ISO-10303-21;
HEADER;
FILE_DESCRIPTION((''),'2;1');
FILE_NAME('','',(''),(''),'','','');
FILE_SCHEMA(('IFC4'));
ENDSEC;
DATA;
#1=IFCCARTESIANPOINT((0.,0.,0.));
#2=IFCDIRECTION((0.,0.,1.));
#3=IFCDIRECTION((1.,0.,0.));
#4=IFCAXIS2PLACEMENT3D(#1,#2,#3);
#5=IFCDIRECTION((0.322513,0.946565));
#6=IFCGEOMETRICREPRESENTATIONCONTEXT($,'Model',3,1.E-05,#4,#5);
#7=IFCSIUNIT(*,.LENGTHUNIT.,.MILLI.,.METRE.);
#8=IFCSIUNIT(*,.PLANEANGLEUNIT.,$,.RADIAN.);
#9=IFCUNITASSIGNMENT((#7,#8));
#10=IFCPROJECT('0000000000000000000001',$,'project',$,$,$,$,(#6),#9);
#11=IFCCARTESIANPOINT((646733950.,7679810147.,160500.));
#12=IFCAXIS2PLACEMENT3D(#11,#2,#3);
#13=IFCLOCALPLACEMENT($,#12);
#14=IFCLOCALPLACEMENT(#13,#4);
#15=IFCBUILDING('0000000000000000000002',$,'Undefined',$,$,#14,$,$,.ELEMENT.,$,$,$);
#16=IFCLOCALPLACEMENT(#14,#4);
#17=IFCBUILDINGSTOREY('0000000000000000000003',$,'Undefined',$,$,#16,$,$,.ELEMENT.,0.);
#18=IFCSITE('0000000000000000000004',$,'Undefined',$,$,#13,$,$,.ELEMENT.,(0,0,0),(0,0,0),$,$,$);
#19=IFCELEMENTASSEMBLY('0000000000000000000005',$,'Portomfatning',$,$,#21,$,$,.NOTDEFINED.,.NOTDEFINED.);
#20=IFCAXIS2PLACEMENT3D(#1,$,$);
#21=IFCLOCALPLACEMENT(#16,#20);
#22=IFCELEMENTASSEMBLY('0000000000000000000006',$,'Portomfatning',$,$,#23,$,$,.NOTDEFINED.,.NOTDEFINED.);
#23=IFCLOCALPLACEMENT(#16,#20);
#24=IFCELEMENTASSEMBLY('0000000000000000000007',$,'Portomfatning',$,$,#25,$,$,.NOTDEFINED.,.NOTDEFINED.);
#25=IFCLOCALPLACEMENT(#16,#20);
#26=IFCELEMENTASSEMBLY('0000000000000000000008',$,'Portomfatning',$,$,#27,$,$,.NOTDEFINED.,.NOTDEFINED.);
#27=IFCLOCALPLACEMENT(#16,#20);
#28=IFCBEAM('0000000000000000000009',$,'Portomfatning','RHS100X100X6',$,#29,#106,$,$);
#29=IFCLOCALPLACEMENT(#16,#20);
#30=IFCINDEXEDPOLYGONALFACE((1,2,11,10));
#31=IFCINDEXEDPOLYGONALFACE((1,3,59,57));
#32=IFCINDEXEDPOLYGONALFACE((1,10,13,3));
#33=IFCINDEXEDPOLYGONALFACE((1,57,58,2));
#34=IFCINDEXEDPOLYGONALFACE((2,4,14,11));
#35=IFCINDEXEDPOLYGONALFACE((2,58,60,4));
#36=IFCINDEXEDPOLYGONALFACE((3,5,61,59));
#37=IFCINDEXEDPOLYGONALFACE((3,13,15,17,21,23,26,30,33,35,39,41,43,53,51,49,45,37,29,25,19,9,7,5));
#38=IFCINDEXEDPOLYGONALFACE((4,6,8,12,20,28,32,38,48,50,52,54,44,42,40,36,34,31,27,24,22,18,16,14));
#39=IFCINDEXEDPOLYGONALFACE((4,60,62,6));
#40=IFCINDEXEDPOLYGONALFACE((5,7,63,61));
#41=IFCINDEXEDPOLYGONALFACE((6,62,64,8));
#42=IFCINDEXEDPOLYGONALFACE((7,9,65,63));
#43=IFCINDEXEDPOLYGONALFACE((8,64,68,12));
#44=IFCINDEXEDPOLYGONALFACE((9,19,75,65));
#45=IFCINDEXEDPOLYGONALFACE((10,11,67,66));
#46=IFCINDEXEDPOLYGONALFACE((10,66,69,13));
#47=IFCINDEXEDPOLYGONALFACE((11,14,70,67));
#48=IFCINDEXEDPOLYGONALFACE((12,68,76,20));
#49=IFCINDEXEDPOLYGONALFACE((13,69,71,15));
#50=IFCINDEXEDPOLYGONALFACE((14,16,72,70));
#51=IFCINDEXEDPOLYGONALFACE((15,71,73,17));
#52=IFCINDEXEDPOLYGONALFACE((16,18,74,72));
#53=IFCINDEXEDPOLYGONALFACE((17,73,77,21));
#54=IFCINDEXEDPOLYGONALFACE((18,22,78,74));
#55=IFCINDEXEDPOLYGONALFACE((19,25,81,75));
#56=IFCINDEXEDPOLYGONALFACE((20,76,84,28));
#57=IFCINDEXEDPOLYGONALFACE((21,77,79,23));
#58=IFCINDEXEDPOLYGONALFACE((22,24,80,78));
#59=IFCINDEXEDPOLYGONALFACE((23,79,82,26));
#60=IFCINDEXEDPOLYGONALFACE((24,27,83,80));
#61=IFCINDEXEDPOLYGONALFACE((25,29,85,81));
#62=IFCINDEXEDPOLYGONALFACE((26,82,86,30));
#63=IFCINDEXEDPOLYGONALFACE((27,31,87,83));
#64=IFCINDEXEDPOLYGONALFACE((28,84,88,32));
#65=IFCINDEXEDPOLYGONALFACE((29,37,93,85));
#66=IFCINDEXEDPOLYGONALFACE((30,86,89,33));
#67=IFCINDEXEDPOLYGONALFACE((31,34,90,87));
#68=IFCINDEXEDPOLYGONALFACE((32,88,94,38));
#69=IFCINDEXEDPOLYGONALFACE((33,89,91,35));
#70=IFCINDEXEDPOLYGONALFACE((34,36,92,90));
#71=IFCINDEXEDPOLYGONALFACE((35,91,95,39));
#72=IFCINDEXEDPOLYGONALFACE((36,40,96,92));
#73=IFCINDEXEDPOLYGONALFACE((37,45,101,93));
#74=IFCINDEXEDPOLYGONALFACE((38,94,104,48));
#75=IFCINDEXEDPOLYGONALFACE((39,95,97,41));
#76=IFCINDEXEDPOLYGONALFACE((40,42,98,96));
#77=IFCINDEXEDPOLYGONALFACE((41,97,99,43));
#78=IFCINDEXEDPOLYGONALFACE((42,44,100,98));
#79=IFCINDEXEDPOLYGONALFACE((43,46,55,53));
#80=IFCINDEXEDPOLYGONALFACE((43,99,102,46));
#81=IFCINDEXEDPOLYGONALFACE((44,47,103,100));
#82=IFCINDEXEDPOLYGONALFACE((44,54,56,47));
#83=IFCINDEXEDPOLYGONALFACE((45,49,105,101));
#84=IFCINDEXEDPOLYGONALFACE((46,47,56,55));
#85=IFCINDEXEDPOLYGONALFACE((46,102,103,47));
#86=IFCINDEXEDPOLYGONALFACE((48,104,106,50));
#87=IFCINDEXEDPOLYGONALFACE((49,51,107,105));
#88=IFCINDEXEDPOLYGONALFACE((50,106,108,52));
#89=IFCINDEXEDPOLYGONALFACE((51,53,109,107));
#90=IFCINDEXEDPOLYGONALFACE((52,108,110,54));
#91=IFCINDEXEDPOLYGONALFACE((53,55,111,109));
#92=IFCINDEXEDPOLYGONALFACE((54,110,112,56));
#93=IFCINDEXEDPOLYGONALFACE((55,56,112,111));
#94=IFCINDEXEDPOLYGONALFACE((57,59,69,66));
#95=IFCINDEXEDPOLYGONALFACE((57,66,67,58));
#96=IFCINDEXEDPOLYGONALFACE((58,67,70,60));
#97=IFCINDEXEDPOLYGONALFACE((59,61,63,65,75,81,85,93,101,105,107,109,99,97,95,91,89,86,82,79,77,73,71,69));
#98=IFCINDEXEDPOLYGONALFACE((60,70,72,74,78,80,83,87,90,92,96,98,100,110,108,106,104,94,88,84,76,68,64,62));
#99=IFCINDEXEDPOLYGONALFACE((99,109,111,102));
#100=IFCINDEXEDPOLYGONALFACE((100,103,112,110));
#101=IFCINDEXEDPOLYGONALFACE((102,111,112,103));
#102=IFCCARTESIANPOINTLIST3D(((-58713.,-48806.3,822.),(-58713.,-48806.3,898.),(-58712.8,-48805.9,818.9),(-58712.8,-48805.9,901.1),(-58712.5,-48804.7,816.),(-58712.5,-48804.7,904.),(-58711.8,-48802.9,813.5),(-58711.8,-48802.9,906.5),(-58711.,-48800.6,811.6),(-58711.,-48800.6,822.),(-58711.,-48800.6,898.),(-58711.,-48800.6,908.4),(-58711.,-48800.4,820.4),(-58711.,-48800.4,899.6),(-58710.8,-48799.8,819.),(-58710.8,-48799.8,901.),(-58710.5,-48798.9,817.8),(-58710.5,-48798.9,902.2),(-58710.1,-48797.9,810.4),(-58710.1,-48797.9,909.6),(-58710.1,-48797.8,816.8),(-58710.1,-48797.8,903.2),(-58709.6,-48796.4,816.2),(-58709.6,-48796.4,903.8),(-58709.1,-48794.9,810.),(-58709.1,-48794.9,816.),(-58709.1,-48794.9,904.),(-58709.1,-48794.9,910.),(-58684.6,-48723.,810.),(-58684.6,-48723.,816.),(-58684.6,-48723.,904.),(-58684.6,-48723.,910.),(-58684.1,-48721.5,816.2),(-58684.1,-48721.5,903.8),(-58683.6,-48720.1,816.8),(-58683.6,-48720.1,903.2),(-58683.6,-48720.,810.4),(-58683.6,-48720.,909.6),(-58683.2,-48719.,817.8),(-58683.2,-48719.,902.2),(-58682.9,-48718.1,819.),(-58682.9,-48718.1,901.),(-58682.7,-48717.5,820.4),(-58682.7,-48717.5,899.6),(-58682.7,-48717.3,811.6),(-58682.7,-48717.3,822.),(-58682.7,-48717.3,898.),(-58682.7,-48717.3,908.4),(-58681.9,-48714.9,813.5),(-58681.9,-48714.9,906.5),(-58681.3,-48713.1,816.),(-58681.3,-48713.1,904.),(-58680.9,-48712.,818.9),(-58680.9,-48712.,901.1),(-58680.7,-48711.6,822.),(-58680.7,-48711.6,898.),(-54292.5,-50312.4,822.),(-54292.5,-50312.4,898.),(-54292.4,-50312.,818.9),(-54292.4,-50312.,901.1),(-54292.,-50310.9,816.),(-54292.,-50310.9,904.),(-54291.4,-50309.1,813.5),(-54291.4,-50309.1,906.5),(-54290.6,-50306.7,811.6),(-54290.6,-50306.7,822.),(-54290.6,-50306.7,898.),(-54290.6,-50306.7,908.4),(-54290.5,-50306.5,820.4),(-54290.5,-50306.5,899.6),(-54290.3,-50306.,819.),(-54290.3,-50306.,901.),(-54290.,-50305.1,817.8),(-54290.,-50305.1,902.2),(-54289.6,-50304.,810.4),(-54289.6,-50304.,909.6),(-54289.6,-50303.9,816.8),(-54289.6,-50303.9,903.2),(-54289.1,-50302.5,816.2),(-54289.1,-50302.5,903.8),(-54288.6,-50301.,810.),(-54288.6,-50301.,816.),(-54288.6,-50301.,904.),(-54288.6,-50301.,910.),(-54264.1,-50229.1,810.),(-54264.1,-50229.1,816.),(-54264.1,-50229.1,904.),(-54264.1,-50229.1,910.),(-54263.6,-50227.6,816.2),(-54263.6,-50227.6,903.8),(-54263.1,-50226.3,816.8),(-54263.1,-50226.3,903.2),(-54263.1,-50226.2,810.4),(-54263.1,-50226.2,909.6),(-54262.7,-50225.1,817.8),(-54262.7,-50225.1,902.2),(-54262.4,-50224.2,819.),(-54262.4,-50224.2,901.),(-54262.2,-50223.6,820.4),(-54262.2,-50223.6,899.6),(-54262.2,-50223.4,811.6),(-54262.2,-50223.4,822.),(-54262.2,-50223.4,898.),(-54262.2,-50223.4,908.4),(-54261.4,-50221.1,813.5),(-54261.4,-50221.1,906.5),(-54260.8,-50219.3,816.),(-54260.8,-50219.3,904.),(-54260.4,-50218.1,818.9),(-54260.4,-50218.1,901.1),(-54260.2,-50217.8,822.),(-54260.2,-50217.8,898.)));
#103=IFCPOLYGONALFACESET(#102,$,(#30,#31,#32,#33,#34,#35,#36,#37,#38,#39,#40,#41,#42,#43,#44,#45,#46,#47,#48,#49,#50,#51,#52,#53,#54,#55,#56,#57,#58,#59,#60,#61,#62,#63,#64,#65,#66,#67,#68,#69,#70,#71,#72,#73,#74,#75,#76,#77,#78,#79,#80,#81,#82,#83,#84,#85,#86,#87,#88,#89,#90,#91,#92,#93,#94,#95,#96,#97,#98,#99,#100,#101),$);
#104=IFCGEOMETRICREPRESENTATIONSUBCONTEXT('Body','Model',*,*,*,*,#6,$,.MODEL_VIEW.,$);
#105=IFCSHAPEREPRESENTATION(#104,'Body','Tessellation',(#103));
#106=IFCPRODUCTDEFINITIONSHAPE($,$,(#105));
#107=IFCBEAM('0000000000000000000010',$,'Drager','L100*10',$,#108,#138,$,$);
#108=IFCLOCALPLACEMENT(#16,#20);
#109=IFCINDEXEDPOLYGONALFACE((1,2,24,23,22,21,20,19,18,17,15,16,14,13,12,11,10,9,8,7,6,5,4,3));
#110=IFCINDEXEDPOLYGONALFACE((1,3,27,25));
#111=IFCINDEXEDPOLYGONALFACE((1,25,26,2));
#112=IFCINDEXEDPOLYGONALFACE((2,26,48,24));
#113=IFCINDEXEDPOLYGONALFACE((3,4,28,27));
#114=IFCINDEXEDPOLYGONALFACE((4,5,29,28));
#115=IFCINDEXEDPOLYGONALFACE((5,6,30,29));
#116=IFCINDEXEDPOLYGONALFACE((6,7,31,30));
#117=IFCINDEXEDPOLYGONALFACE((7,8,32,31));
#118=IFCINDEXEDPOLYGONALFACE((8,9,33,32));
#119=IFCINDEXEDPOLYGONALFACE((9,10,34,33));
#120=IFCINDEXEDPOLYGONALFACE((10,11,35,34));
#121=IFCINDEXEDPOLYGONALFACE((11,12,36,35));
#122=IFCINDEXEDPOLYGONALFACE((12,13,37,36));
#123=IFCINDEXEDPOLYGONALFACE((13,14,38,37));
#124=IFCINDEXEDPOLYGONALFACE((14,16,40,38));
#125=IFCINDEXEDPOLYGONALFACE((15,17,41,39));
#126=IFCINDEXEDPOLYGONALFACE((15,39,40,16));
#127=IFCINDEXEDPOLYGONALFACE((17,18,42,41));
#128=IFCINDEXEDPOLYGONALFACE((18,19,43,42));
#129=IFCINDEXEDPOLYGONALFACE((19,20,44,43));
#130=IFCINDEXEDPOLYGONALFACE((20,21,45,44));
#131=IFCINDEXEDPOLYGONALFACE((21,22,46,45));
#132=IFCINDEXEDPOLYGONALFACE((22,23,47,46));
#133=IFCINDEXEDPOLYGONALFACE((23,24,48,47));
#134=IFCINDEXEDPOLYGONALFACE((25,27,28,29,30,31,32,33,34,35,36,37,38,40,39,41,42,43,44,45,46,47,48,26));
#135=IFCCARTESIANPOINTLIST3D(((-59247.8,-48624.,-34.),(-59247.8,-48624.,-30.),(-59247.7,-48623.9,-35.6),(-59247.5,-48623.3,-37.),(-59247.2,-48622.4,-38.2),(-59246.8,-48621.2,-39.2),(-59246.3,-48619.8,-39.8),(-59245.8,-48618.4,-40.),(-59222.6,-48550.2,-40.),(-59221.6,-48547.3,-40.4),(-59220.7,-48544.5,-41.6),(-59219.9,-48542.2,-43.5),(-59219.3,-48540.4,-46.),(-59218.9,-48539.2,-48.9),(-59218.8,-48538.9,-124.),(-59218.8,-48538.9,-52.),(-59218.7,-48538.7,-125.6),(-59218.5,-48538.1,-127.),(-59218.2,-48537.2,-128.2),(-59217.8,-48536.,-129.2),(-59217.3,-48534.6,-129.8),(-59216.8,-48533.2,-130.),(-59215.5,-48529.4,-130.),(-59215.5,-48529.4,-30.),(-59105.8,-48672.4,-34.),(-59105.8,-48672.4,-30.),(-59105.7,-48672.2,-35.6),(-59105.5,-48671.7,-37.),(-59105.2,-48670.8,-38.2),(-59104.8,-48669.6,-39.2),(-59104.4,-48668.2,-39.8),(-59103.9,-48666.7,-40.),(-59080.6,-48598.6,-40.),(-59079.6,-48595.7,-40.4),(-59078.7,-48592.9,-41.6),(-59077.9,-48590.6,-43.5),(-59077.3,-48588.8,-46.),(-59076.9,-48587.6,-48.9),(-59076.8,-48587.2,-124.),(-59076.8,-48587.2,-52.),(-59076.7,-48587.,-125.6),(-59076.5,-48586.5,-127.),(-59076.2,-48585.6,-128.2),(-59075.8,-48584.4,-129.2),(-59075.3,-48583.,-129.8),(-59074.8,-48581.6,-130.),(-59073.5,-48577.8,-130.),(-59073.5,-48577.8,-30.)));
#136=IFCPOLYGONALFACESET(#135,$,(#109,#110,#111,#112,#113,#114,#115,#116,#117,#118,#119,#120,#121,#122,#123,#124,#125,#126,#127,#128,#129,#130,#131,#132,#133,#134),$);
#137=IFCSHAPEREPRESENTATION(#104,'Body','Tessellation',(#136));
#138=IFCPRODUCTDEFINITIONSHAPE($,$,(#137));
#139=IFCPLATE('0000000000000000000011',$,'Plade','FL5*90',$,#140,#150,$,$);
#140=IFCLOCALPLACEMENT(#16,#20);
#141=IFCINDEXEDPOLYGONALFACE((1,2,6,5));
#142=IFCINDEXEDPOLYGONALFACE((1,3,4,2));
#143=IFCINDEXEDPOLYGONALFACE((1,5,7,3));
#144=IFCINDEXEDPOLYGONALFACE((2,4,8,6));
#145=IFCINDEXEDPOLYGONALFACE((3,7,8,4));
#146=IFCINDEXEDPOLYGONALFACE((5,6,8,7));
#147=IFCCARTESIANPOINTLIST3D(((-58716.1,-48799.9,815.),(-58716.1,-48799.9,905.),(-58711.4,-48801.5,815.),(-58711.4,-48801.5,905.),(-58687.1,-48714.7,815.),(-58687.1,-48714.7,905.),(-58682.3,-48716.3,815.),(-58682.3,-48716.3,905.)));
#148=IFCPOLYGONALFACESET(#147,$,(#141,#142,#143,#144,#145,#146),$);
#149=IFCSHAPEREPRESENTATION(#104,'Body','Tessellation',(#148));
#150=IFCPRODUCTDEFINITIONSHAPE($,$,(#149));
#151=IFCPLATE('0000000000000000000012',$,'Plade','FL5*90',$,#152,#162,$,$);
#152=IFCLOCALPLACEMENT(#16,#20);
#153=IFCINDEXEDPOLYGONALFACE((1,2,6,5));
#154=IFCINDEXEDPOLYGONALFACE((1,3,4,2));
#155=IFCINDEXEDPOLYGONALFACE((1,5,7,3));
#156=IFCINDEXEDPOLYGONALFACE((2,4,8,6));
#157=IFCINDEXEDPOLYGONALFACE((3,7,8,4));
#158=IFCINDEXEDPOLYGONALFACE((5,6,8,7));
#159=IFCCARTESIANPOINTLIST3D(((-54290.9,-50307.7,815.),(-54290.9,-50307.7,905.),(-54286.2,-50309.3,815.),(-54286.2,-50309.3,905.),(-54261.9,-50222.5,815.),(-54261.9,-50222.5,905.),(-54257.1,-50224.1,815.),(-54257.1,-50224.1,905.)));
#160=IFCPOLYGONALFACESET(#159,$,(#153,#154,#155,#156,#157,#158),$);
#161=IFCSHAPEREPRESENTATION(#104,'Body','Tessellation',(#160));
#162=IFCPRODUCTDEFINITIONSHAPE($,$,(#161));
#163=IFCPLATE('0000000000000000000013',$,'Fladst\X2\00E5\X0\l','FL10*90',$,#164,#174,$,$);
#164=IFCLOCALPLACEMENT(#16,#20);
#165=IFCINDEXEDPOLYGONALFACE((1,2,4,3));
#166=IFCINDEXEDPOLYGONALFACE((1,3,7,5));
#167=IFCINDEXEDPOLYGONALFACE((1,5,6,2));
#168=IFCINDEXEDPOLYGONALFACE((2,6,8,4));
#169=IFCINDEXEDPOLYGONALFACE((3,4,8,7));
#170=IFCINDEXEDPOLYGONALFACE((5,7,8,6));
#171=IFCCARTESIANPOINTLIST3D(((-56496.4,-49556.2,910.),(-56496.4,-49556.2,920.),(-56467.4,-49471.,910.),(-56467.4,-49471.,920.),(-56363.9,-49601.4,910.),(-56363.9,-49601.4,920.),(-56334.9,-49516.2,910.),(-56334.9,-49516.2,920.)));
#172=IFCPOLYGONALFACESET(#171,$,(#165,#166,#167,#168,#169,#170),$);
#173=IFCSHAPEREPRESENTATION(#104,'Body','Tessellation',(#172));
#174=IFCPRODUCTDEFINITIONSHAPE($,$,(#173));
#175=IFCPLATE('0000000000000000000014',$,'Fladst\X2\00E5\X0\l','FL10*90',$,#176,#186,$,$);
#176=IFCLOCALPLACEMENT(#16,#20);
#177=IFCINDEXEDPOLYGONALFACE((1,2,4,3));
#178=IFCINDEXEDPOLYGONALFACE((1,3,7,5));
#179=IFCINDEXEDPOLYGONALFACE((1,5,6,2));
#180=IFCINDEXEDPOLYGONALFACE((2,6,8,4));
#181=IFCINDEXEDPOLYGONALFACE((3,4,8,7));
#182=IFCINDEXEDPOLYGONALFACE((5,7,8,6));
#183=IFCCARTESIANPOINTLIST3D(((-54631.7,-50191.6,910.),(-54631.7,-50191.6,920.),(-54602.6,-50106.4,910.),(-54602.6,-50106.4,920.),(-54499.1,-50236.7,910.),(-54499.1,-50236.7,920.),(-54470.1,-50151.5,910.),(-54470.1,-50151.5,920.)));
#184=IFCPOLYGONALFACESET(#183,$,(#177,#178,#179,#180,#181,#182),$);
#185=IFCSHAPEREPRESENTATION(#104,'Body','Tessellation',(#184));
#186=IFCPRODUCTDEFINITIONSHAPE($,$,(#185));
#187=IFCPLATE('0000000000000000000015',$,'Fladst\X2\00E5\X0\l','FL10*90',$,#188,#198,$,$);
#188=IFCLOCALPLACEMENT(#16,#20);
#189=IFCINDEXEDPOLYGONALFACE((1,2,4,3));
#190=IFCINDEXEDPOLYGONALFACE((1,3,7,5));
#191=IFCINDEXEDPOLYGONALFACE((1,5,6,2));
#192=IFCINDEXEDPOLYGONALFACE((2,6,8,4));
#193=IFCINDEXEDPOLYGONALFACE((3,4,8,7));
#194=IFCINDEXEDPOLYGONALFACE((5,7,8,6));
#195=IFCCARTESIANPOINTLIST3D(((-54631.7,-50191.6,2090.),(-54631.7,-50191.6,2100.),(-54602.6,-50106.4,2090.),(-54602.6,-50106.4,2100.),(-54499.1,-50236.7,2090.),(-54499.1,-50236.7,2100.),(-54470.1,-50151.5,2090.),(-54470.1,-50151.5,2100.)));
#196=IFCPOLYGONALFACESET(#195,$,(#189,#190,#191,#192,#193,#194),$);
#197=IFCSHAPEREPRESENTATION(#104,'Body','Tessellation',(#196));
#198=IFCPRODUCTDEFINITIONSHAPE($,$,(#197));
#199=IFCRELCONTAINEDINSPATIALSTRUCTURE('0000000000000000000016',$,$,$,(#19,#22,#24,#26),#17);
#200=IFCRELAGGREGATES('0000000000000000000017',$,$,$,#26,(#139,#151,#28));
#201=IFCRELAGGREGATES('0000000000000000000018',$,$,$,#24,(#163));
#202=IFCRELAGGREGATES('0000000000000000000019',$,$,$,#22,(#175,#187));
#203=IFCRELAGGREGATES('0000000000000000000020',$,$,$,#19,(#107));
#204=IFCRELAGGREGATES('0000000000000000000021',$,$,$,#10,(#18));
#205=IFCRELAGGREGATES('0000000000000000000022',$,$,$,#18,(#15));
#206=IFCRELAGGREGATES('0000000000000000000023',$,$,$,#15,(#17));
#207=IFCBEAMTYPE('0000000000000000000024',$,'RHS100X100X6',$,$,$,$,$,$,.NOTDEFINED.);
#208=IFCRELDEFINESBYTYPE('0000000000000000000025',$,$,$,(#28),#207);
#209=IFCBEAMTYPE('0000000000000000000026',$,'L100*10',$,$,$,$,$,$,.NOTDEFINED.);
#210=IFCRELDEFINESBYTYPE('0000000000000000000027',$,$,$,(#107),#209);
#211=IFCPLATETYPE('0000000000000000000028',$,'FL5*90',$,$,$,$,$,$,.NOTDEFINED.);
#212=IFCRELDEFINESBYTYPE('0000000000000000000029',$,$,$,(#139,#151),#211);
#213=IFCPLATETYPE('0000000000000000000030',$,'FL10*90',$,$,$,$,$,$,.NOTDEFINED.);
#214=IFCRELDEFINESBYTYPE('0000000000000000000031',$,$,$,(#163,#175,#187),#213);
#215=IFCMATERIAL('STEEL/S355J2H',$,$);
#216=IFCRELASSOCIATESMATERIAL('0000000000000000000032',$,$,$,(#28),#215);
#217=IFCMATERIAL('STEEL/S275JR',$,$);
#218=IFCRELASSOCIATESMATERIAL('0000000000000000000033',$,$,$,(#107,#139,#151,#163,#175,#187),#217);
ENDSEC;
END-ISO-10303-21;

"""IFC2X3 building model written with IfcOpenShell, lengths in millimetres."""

from ifc_helpers import new_model, si_unit, direction, frame, origin_with_axes, origin_2d_with_axis, place, context, subcontext, project, spatial, polyline, hollow_rectangle, l_section, outline, extrude, clip, halfspace, material, type_object, element, aggregate, save


model = new_model("IFC2X3")

# Units and contexts
model_context = context("Model", 3, precision=1e-05, world=origin_with_axes(), true_north=direction((0.322513, 0.946565)))
body_context = subcontext(model_context, "Body", "Model", "MODEL_VIEW")
ifc_project = project(units=[si_unit("LENGTHUNIT", "METRE", prefix="MILLI"), si_unit("PLANEANGLEUNIT", "RADIAN")], contexts=[model_context])

# Site, building, storey
site_placement = place(None, frame((646733950.0, 7679810147.0, 160500.0), z_axis=(0.0, 0.0, 1.0), x_axis=(1.0, 0.0, 0.0)))
site = spatial("IfcSite", under=ifc_project, at=site_placement, Name="Undefined", CompositionType="ELEMENT", RefLatitude=(0, 0, 0), RefLongitude=(0, 0, 0))
building_placement = place(site_placement, origin_with_axes())
building = spatial("IfcBuilding", under=site, at=building_placement, Name="Undefined", CompositionType="ELEMENT")
storey_placement = place(building_placement, origin_with_axes())
storey = spatial("IfcBuildingStorey", under=building, at=storey_placement, Name="Undefined", CompositionType="ELEMENT", Elevation=0.0)

# Element assemblies
assembly_1_placement = place(storey_placement, origin_with_axes())
assembly_1 = element("IfcElementAssembly", 1, at=assembly_1_placement, inside=storey, Name="Portomfatning", AssemblyPlace="NOTDEFINED", PredefinedType="NOTDEFINED")
ifc_material_1 = material(Name="STEEL/S355J2H")
assembly_2_placement = place(storey_placement, origin_with_axes())
assembly_2 = element("IfcElementAssembly", 2, at=assembly_2_placement, inside=storey, Name="Portomfatning", AssemblyPlace="NOTDEFINED", PredefinedType="NOTDEFINED")
assembly_3_placement = place(storey_placement, origin_with_axes())
assembly_3 = element("IfcElementAssembly", 3, at=assembly_3_placement, inside=storey, Name="Portomfatning", AssemblyPlace="NOTDEFINED", PredefinedType="NOTDEFINED")

# Element assembly, beam
assembly_4_placement = place(storey_placement, origin_with_axes())
assembly_4 = element("IfcElementAssembly", 4, at=assembly_4_placement, inside=storey, Name="Portomfatning", AssemblyPlace="NOTDEFINED", PredefinedType="NOTDEFINED")
beam_type_1 = type_object("IfcBeamType", Name="RHS100X100X6", PredefinedType="NOTDEFINED")
beam_1_placement = place(assembly_4_placement, frame((-58711.0, -48754.1, 860.0), z_axis=(0.322513, 0.946565, 0.0), x_axis=(0.946565, -0.322513, 0.0)))
beam_1 = element("IfcBeam", 5, at=beam_1_placement, type_object=beam_type_1, material=ifc_material_1, Name="Portomfatning", Description="RHS100X100X6", context=body_context, shape_type="Clipping", body=[
    clip(clip(extrude(hollow_rectangle(XDim=100.0, YDim=100.0, WallThickness=6.0, InnerFilletRadius=6.0, OuterFilletRadius=12.0, at=origin_2d_with_axis()), frame((4746.7, 0.0, 0.0), z_axis=(-1.0, 0.0, 0.0), x_axis=(0.0, -1.0, 0.0)), (0.0, 0.0, 1.0), 4793.4), halfspace(frame((4685.0, -50.0, -50.0), z_axis=(-1.0, 0.0, 0.000185), x_axis=(0.0, 1.0, 0.0)), True)), halfspace(frame((15.0, 50.0, -50.0), z_axis=(1.0, 0.0, 0.000185), x_axis=(0.0, -1.0, 0.0)), True)),
])

# Beam
ifc_material_2 = material(Name="STEEL/S275JR")
beam_type_2 = type_object("IfcBeamType", Name="L100*10", PredefinedType="NOTDEFINED")
beam_2_placement = place(assembly_1_placement, frame((-59231.7, -48576.7, -80.0), z_axis=(-0.322513, -0.946565, 0.0), x_axis=(0.946565, -0.322513, 0.0)))
beam_2 = element("IfcBeam", 6, at=beam_2_placement, type_object=beam_type_2, material=ifc_material_2, Name="Drager", Description="L100*10", context=body_context, shape_type="SweptSolid", body=[
    extrude(l_section(Depth=100.0, Width=100.0, Thickness=10.0, FilletRadius=12.0, EdgeRadius=6.0, at=origin_2d_with_axis()), frame((150.0, 0.0, 0.0), z_axis=(-1.0, 0.0, 0.0), x_axis=(0.0, -1.0, 0.0)), (0.0, 0.0, 1.0), 150.0),
])

# Plates
plate_type_1 = type_object("IfcPlateType", Name="FL5*90", PredefinedType="NOTDEFINED")
plate_1_placement = place(assembly_4_placement, frame((-58684.7, -48715.5, 905.0), z_axis=(-0.946625, 0.322338, 0.0), x_axis=(0.0, 0.0, -1.0)))
plate_1 = element("IfcPlate", 7, at=plate_1_placement, type_object=plate_type_1, material=ifc_material_2, Name="Plade", Description="FL5*90", context=body_context, shape_type="SweptSolid", body=[
    extrude(outline(polyline([(0.0, 0.0), (90.0, 0.0), (90.0, 90.0), (0.0, 90.0), (0.0, 0.0)])), frame((0.0, 0.0, -2.5), z_axis=(0.0, 0.0, 1.0), x_axis=(1.0, 0.0, 0.0)), (0.0, 0.0, 1.0), 5.0),
])
plate_2_placement = place(assembly_4_placement, frame((-54259.5, -50223.3, 815.0), z_axis=(0.946505, -0.322688, 0.0), x_axis=(0.0, 0.0, 1.0)))
plate_2 = element("IfcPlate", 8, at=plate_2_placement, type_object=plate_type_1, material=ifc_material_2, Name="Plade", Description="FL5*90", context=body_context, shape_type="SweptSolid", body=[
    extrude(outline(polyline([(0.0, 0.0), (90.0, 0.0), (90.0, 90.0), (0.0, 90.0), (0.0, 0.0)])), frame((0.0, 0.0, -2.5), z_axis=(0.0, 0.0, 1.0), x_axis=(1.0, 0.0, 0.0)), (0.0, 0.0, 1.0), 5.0),
])
aggregate(assembly_4, [plate_1, plate_2, beam_1])
plate_type_2 = type_object("IfcPlateType", Name="FL10*90", PredefinedType="NOTDEFINED")
plate_3_placement = place(assembly_3_placement, frame((-56349.4, -49558.8, 915.0), z_axis=(0.0, 0.0, 1.0), x_axis=(-0.946565, 0.322513, 0.0)))
plate_3 = element("IfcPlate", 9, at=plate_3_placement, type_object=plate_type_2, material=ifc_material_2, Name="Fladstål", Description="FL10*90", context=body_context, shape_type="SweptSolid", body=[
    extrude(outline(polyline([(0.0, -45.0), (0.0, 45.0), (140.0, 45.0), (140.0, -45.0), (0.0, -45.0)])), frame((0.0, 0.0, -5.0), z_axis=(0.0, 0.0, 1.0), x_axis=(1.0, 0.0, 0.0)), (0.0, 0.0, 1.0), 10.0),
])
plate_4_placement = place(assembly_2_placement, frame((-54617.1, -50149.0, 915.0), z_axis=(0.0, 0.0, 1.0), x_axis=(0.946565, -0.322513, 0.0)))
plate_4 = element("IfcPlate", 10, at=plate_4_placement, type_object=plate_type_2, material=ifc_material_2, Name="Fladstål", Description="FL10*90", context=body_context, shape_type="SweptSolid", body=[
    extrude(outline(polyline([(0.0, -45.0), (0.0, 45.0), (140.0, 45.0), (140.0, -45.0), (0.0, -45.0)])), frame((0.0, 0.0, -5.0), z_axis=(0.0, 0.0, 1.0), x_axis=(1.0, 0.0, 0.0)), (0.0, 0.0, 1.0), 10.0),
])
plate_5_placement = place(assembly_2_placement, frame((-54617.1, -50149.0, 2095.0), z_axis=(0.0, 0.0, -1.0), x_axis=(0.946565, -0.322513, 0.0)))
plate_5 = element("IfcPlate", 11, at=plate_5_placement, type_object=plate_type_2, material=ifc_material_2, Name="Fladstål", Description="FL10*90", context=body_context, shape_type="SweptSolid", body=[
    extrude(outline(polyline([(0.0, -45.0), (0.0, 45.0), (140.0, 45.0), (140.0, -45.0), (0.0, -45.0)])), frame((0.0, 0.0, -5.0), z_axis=(0.0, 0.0, 1.0), x_axis=(1.0, 0.0, 0.0)), (0.0, 0.0, 1.0), 10.0),
])

aggregate(assembly_3, [plate_3])
aggregate(assembly_2, [plate_4, plate_5])
aggregate(assembly_1, [beam_2])

save(model, "model.ifc")
